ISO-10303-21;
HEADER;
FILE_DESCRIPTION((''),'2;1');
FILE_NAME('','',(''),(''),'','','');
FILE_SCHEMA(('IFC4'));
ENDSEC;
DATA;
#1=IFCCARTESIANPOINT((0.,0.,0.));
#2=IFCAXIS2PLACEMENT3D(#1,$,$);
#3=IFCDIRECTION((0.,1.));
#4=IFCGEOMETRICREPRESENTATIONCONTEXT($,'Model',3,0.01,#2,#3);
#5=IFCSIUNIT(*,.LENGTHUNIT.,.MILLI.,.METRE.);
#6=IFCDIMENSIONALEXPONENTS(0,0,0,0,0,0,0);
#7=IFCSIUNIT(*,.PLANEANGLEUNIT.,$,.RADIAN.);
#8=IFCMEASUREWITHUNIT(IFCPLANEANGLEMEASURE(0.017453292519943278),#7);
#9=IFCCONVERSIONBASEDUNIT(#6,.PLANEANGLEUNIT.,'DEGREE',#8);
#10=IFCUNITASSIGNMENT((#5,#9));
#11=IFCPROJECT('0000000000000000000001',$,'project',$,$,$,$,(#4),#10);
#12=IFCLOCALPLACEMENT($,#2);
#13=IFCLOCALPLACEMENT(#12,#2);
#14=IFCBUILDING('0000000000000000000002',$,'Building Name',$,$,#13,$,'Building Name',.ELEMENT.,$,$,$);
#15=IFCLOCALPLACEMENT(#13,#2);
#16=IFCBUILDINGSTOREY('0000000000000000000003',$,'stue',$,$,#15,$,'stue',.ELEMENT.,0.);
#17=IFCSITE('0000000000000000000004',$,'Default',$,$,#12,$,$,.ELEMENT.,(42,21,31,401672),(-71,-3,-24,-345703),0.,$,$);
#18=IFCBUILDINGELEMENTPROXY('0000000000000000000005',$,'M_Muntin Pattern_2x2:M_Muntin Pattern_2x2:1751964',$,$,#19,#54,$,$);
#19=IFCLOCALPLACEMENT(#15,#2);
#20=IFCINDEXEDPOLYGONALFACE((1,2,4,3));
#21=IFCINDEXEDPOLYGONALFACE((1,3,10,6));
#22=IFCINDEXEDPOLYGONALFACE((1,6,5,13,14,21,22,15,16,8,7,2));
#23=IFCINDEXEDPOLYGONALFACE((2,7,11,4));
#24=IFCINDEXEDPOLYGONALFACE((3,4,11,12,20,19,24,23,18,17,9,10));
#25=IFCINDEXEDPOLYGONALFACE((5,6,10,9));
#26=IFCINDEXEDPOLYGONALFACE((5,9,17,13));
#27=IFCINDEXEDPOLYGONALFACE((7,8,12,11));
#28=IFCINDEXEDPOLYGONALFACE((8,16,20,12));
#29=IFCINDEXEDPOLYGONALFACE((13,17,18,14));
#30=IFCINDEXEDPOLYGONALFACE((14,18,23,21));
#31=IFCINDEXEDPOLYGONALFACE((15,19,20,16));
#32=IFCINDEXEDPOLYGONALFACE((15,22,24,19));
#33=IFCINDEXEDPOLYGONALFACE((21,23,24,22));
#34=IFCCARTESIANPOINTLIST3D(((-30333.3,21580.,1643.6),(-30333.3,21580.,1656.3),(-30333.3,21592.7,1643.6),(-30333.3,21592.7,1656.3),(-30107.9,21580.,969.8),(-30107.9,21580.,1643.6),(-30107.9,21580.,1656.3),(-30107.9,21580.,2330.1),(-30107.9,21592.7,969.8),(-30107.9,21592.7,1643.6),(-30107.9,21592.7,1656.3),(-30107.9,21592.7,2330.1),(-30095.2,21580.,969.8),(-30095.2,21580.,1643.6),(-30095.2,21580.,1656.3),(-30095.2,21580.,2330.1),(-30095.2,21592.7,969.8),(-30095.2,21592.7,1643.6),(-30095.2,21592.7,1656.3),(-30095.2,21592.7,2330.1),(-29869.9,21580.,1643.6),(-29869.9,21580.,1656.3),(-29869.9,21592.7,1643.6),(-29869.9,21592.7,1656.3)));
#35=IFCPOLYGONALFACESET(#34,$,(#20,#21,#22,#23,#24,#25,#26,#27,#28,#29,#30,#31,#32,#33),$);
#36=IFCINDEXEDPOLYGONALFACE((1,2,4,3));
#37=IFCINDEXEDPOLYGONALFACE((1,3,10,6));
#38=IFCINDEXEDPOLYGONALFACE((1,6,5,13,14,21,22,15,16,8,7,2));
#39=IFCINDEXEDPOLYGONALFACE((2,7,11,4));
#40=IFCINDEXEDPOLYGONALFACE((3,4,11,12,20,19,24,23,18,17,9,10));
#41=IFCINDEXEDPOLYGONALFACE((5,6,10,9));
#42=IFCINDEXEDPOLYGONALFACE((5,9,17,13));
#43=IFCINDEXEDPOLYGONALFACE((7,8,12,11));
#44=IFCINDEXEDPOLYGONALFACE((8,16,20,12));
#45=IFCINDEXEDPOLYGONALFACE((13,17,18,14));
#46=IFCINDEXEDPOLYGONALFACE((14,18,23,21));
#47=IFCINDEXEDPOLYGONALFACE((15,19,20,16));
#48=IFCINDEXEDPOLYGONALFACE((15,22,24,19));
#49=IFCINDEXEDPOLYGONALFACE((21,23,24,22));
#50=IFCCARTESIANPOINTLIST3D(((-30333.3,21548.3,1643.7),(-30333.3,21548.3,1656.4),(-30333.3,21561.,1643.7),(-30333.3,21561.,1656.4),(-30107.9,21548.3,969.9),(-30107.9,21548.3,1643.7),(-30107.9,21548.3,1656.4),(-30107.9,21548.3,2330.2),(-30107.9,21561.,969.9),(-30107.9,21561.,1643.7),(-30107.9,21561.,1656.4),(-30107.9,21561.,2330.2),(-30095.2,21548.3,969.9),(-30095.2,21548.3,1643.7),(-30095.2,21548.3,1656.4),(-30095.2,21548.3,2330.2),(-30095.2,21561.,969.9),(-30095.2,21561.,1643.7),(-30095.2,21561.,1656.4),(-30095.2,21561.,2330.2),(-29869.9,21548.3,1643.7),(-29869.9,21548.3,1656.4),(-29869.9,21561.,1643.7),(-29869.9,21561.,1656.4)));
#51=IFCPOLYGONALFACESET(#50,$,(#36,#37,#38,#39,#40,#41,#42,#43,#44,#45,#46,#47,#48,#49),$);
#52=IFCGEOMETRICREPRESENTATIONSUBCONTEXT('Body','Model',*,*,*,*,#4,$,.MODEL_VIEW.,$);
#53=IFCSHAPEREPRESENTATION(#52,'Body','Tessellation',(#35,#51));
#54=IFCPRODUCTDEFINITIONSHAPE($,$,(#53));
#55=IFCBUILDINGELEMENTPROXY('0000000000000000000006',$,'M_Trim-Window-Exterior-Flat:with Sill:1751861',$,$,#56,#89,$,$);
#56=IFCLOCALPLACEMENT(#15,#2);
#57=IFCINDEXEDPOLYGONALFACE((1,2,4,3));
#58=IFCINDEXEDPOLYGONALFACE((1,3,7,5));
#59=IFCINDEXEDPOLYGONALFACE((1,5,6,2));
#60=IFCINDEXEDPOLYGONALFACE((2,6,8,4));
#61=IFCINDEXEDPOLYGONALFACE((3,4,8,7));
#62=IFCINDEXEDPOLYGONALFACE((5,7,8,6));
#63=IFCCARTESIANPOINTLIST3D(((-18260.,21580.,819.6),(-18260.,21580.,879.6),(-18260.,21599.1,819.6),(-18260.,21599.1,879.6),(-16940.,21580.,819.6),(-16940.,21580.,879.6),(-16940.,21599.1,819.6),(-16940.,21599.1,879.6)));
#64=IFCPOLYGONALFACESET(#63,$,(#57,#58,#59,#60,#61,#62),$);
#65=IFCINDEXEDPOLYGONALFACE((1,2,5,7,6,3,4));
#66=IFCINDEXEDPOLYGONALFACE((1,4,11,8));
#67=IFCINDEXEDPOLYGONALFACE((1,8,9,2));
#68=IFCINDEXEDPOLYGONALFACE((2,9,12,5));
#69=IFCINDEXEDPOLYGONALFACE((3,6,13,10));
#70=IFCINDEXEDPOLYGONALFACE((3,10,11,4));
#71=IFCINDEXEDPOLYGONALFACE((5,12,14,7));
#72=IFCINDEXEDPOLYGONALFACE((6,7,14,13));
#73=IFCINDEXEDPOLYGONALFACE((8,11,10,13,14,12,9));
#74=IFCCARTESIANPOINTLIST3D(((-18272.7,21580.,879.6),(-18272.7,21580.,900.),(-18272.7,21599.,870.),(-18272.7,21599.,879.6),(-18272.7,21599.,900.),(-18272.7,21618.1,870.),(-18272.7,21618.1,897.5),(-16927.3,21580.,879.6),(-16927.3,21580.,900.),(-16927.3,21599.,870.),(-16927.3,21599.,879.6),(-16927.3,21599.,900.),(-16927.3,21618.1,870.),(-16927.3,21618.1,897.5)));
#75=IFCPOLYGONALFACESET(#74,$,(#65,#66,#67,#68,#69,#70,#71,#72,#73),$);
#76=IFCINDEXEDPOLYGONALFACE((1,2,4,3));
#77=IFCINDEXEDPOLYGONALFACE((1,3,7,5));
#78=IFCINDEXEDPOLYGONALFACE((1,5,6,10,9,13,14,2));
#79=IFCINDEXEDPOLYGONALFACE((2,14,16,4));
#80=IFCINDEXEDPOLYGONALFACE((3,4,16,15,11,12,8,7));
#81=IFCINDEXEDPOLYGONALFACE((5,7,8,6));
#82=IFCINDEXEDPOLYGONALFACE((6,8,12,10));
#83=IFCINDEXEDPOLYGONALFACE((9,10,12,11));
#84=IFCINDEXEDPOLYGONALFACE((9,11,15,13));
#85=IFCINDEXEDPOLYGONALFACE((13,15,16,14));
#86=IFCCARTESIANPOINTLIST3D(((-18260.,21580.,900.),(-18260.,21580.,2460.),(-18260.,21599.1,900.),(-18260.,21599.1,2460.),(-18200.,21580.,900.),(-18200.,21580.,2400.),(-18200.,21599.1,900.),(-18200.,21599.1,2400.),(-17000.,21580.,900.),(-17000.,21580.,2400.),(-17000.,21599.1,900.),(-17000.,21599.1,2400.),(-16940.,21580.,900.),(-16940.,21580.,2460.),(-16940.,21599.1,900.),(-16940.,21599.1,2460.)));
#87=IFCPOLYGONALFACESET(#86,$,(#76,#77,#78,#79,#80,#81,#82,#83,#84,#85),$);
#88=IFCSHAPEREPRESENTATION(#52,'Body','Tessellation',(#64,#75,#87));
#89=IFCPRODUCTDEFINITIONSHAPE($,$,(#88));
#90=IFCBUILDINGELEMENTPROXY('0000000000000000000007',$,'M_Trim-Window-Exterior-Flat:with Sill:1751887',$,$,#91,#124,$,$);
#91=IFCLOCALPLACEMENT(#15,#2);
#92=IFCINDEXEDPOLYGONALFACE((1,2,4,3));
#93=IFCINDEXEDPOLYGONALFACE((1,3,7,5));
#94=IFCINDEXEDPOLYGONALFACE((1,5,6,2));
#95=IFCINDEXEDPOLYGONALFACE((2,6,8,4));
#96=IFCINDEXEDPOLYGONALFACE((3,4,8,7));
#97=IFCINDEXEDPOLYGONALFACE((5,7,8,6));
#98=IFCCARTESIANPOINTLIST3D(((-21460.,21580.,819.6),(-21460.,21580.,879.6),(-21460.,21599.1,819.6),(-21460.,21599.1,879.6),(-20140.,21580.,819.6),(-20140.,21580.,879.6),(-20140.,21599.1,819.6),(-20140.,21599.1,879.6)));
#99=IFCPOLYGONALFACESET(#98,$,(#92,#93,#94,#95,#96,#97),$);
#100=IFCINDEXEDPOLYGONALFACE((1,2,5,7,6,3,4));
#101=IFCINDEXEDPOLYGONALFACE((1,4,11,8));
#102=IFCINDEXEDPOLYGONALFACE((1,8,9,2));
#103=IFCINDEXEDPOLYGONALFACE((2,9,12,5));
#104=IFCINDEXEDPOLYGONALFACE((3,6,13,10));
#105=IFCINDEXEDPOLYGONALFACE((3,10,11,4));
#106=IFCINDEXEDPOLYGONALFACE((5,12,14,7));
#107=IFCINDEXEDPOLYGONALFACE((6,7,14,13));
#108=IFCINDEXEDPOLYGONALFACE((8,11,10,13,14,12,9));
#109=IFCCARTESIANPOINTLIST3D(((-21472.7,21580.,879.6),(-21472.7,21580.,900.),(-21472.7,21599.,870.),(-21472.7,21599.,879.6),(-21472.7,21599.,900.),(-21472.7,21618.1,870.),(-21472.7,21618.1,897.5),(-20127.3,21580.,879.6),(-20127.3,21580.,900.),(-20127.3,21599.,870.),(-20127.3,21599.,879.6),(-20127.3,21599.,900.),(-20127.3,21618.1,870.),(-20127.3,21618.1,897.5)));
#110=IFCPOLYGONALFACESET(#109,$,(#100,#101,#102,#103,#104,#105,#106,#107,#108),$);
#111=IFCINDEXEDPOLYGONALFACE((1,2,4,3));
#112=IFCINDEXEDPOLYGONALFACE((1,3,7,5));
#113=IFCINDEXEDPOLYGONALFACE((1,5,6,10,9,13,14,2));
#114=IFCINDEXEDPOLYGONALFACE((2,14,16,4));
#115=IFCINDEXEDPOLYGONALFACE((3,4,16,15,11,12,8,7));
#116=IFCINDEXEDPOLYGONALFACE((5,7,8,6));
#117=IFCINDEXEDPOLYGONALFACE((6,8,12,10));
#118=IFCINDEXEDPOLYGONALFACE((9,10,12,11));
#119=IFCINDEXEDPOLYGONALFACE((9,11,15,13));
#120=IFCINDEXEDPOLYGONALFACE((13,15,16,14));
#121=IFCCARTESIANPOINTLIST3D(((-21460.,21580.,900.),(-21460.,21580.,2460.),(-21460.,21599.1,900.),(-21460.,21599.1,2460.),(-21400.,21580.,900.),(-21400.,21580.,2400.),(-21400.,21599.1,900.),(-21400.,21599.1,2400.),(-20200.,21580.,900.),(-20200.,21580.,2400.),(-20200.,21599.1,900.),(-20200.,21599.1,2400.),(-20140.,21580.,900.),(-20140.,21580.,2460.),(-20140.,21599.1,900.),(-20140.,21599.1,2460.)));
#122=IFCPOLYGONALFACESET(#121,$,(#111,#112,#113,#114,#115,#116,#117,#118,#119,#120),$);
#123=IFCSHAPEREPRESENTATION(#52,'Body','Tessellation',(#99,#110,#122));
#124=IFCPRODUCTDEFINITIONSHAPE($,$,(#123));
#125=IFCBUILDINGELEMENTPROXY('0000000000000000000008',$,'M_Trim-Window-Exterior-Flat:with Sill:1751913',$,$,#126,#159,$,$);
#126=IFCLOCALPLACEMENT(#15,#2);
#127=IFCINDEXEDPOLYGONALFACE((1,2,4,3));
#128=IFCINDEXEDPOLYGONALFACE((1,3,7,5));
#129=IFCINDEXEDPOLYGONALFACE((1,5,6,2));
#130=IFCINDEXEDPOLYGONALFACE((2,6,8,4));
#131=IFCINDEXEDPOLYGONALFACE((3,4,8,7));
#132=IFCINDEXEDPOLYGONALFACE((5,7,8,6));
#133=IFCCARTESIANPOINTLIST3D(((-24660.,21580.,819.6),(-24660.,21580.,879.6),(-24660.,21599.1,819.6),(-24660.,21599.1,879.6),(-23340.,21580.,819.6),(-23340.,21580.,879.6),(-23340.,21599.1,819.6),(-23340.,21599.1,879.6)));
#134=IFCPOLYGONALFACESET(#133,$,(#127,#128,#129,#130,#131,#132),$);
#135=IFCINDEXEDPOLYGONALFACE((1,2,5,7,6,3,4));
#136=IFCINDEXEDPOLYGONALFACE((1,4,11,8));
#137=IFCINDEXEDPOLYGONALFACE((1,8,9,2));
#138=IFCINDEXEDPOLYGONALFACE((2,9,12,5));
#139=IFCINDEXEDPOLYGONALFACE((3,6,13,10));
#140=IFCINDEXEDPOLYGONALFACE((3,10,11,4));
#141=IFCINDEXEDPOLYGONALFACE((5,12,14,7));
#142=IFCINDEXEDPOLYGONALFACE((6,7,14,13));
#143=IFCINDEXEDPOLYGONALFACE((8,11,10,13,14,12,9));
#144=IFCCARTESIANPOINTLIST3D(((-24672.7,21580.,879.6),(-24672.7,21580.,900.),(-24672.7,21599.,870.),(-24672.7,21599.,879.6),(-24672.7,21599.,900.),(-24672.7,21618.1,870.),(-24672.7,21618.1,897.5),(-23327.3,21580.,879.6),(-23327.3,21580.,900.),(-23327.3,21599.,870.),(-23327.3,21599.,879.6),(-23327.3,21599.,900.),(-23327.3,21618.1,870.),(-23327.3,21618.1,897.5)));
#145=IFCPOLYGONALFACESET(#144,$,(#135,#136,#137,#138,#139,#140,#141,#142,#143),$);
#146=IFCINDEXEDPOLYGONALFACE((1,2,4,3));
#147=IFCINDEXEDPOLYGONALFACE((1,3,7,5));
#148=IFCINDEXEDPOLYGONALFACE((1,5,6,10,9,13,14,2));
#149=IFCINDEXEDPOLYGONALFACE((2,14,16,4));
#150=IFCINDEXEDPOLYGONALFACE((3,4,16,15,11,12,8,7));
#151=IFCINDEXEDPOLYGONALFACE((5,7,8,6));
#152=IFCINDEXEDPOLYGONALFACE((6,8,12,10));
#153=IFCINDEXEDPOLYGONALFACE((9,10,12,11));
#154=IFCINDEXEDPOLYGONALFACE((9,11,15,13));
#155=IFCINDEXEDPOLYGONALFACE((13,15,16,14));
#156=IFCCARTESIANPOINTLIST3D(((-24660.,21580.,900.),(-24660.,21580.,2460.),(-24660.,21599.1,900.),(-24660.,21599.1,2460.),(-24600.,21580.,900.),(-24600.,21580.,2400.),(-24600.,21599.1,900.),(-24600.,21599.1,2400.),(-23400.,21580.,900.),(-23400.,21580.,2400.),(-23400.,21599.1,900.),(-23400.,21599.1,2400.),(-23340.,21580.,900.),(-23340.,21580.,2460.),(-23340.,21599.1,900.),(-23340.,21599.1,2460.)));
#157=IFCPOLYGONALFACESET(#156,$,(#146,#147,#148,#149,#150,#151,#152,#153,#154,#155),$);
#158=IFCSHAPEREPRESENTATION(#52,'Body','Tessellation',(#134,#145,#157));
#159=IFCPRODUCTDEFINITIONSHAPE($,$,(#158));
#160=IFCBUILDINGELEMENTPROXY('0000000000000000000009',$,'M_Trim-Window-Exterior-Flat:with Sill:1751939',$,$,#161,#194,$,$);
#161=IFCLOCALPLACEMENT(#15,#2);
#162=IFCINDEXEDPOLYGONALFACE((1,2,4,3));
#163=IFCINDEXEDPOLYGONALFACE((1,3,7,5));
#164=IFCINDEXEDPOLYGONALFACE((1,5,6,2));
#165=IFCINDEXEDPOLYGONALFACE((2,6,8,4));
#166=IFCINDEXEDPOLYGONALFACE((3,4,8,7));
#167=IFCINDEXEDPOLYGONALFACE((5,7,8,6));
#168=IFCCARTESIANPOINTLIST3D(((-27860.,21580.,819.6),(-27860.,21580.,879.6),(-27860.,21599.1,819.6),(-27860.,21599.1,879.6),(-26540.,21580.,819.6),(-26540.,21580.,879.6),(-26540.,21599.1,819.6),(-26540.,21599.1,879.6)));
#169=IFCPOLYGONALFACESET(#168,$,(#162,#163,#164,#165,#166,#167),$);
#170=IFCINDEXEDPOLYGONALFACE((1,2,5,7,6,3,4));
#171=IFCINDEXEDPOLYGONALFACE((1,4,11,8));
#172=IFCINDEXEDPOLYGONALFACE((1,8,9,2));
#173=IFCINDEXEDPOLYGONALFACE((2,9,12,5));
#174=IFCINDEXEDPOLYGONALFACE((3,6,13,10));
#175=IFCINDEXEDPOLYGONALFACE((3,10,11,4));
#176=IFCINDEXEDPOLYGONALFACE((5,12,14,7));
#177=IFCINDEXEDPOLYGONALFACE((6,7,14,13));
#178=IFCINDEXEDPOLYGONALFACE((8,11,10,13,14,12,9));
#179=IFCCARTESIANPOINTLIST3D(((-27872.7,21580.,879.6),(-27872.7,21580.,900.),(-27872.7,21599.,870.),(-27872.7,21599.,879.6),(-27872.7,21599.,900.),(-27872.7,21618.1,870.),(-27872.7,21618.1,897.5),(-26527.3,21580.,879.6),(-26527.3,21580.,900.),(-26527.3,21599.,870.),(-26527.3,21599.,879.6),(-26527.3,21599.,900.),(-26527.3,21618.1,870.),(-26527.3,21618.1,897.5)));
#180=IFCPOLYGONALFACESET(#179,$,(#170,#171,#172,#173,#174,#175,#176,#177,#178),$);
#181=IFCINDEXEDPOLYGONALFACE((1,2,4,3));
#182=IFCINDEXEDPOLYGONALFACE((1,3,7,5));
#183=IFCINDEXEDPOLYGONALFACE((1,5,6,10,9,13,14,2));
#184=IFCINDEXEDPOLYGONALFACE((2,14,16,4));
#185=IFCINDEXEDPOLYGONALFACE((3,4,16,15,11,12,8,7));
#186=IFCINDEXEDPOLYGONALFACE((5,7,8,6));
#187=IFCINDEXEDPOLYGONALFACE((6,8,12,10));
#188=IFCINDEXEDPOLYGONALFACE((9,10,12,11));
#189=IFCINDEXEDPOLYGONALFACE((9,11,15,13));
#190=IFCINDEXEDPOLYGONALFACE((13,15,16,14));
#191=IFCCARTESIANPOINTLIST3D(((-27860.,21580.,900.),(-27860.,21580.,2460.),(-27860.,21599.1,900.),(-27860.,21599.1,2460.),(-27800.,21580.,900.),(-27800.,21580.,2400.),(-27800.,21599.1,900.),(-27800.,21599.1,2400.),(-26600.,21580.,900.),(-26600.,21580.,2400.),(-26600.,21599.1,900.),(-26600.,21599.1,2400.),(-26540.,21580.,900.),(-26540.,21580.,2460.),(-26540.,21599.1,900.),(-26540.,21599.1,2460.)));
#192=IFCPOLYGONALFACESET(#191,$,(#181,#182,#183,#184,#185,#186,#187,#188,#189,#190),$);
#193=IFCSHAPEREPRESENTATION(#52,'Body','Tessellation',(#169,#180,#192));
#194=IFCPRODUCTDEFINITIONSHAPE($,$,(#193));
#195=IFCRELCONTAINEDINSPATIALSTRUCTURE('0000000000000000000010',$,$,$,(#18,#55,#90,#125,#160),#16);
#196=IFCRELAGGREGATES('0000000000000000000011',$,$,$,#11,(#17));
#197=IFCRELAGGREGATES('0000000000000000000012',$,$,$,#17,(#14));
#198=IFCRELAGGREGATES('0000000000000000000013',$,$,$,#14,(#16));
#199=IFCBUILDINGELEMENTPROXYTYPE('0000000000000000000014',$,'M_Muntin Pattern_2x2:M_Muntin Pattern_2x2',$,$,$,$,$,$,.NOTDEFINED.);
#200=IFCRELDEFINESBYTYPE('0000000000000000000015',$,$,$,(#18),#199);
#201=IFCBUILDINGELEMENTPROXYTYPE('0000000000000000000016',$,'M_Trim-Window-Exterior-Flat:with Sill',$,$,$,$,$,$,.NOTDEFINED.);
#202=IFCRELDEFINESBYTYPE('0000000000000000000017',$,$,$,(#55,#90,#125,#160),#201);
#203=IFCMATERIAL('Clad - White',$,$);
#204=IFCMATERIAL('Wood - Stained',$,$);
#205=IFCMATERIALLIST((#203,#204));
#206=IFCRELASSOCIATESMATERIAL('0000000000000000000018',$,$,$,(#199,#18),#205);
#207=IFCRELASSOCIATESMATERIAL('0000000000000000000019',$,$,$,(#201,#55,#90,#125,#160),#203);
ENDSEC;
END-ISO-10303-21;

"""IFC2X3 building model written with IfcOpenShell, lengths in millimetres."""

from ifc_helpers import new_model, entity, si_unit, converted_unit, direction, frame, frame_2d, origin, place, context, subcontext, project, spatial, polyline, rectangle, outline, extrude, source, transform, mapped, material, material_list, type_object, type_shapes, element, save


model = new_model("IFC2X3")

# Units and contexts
model_context = context("Model", 3, precision=0.01, world=origin(), true_north=direction((0.0, 1.0)))
body_context = subcontext(model_context, "Body", "Model", "MODEL_VIEW")
ifc_project = project(units=[si_unit("LENGTHUNIT", "METRE", prefix="MILLI"), converted_unit("PLANEANGLEUNIT", "DEGREE", entity("IfcPlaneAngleMeasure", 0.017453292519943278), si_unit("PLANEANGLEUNIT", "RADIAN"), dimensions=[0, 0, 0, 0, 0, 0, 0])], contexts=[model_context])

# Site, building, storey
site_placement = place(None, origin())
site = spatial("IfcSite", under=ifc_project, at=site_placement, Name="Default", CompositionType="ELEMENT", RefLatitude=(42, 21, 31, 401672), RefLongitude=(-71, -3, -24, -345703), RefElevation=0.0)
building_placement = place(site_placement, origin())
building = spatial("IfcBuilding", under=site, at=building_placement, Name="Building Name", LongName="Building Name", CompositionType="ELEMENT")
storey_placement = place(building_placement, origin())
storey = spatial("IfcBuildingStorey", under=building, at=storey_placement, Name="stue", LongName="stue", CompositionType="ELEMENT", Elevation=0.0)

# Building element proxies
ifc_material_1 = material(Name="Clad - White")
ifc_material_2 = material(Name="Wood - Stained")
ifc_material_list = material_list([ifc_material_1, ifc_material_2])
building_element_proxy_type_1 = type_object("IfcBuildingElementProxyType", Name="M_Muntin Pattern_2x2:M_Muntin Pattern_2x2", PredefinedType="NOTDEFINED", material=ifc_material_list)
shared_shape_1 = source(origin(), body_context, "Body", "SweptSolid", [
    extrude(outline(polyline([(6.4, -6.4), (680.1, -6.4), (680.1, 6.3), (6.4, 6.3), (6.4, 231.7), (-6.3, 231.7), (-6.3, 6.3), (-680.2, 6.3), (-680.2, -6.4), (-6.3, -6.4), (-6.3, -231.7), (6.4, -231.7), (6.4, -6.4)])), frame((0.0, -22.2, 680.1), z_axis=(0.0, 1.0, 0.0), x_axis=(0.0, 0.0, 1.0)), (0.0, 0.0, 1.0), 12.7),
    extrude(outline(polyline([(6.4, -6.4), (680.2, -6.4), (680.2, 6.3), (6.4, 6.3), (6.4, 231.7), (-6.3, 231.7), (-6.3, 6.3), (-680.2, 6.3), (-680.2, -6.4), (-6.3, -6.4), (-6.3, -231.7), (6.4, -231.7), (6.4, -6.4)])), frame((0.0, 9.5, 680.2), z_axis=(0.0, 1.0, 0.0), x_axis=(0.0, 0.0, 1.0)), (0.0, 0.0, 1.0), 12.7),
])
type_shapes(building_element_proxy_type_1, [shared_shape_1])
for number, where, z_axis, x_axis, name in (
    (1, (-30101.6, 21570.5, 969.9), (0.0, 0.0, 1.0), (-1.0, 0.0, 0.0), "M_Muntin Pattern_2x2:M_Muntin Pattern_2x2:1751964"),
):
    element("IfcBuildingElementProxy", number, at=place(storey_placement, frame(where, z_axis=z_axis, x_axis=x_axis)), inside=storey, type_object=building_element_proxy_type_1, material=ifc_material_list, Name=name, context=body_context, shape_type="MappedRepresentation", body=[
        mapped(shared_shape_1, transform((0.0, 0.0, 0.0), scale=1.0)),
    ])
building_element_proxy_type_2 = type_object("IfcBuildingElementProxyType", Name="M_Trim-Window-Exterior-Flat:with Sill", PredefinedType="NOTDEFINED", material=ifc_material_1)
shared_shape_2 = source(origin(), body_context, "Body", "SweptSolid", [
    extrude(rectangle(XDim=1320.0, YDim=60.0, at=frame_2d((0.0, 0.0), x_axis=(1.0, 0.0))), frame((0.0, -1550.4, 0.0), z_axis=(0.0, 0.0, 1.0), x_axis=(-1.0, 0.0, 0.0)), (0.0, 0.0, 1.0), 19.0),
    extrude(outline(polyline([(-19.0, -15.2), (0.0, -15.2), (0.0, -5.7), (19.0, -5.7), (19.0, 14.8), (0.0, 14.8), (-19.0, 12.3), (-19.0, -15.2)])), frame((-672.7, -1514.8, 19.0), z_axis=(1.0, 0.0, 0.0), x_axis=(0.0, 0.0, -1.0)), (0.0, 0.0, 1.0), 1345.4),
    extrude(outline(polyline([(-795.0, -660.0), (765.0, -660.0), (765.0, -600.0), (-735.0, -600.0), (-735.0, 600.0), (765.0, 600.0), (765.0, 660.0), (-795.0, 660.0), (-795.0, -660.0)])), frame((0.0, -735.0, 0.0), z_axis=(0.0, 0.0, 1.0), x_axis=(0.0, -1.0, 0.0)), (0.0, 0.0, 1.0), 19.0),
])
type_shapes(building_element_proxy_type_2, [shared_shape_2])
for number, where, z_axis, x_axis, name in (
    (2, (-17600.0, 21580.0, 2400.0), (0.0, 1.0, 0.0), (-1.0, 0.0, 0.0), "M_Trim-Window-Exterior-Flat:with Sill:1751861"),
    (3, (-20800.0, 21580.0, 2400.0), (0.0, 1.0, 0.0), (-1.0, 0.0, 0.0), "M_Trim-Window-Exterior-Flat:with Sill:1751887"),
    (4, (-24000.0, 21580.0, 2400.0), (0.0, 1.0, 0.0), (-1.0, 0.0, 0.0), "M_Trim-Window-Exterior-Flat:with Sill:1751913"),
    (5, (-27200.0, 21580.0, 2400.0), (0.0, 1.0, 0.0), (-1.0, 0.0, 0.0), "M_Trim-Window-Exterior-Flat:with Sill:1751939"),
):
    element("IfcBuildingElementProxy", number, at=place(storey_placement, frame(where, z_axis=z_axis, x_axis=x_axis)), inside=storey, type_object=building_element_proxy_type_2, material=ifc_material_1, Name=name, context=body_context, shape_type="MappedRepresentation", body=[
        mapped(shared_shape_2, transform((0.0, 0.0, 0.0), scale=1.0)),
    ])

save(model, "model.ifc")
